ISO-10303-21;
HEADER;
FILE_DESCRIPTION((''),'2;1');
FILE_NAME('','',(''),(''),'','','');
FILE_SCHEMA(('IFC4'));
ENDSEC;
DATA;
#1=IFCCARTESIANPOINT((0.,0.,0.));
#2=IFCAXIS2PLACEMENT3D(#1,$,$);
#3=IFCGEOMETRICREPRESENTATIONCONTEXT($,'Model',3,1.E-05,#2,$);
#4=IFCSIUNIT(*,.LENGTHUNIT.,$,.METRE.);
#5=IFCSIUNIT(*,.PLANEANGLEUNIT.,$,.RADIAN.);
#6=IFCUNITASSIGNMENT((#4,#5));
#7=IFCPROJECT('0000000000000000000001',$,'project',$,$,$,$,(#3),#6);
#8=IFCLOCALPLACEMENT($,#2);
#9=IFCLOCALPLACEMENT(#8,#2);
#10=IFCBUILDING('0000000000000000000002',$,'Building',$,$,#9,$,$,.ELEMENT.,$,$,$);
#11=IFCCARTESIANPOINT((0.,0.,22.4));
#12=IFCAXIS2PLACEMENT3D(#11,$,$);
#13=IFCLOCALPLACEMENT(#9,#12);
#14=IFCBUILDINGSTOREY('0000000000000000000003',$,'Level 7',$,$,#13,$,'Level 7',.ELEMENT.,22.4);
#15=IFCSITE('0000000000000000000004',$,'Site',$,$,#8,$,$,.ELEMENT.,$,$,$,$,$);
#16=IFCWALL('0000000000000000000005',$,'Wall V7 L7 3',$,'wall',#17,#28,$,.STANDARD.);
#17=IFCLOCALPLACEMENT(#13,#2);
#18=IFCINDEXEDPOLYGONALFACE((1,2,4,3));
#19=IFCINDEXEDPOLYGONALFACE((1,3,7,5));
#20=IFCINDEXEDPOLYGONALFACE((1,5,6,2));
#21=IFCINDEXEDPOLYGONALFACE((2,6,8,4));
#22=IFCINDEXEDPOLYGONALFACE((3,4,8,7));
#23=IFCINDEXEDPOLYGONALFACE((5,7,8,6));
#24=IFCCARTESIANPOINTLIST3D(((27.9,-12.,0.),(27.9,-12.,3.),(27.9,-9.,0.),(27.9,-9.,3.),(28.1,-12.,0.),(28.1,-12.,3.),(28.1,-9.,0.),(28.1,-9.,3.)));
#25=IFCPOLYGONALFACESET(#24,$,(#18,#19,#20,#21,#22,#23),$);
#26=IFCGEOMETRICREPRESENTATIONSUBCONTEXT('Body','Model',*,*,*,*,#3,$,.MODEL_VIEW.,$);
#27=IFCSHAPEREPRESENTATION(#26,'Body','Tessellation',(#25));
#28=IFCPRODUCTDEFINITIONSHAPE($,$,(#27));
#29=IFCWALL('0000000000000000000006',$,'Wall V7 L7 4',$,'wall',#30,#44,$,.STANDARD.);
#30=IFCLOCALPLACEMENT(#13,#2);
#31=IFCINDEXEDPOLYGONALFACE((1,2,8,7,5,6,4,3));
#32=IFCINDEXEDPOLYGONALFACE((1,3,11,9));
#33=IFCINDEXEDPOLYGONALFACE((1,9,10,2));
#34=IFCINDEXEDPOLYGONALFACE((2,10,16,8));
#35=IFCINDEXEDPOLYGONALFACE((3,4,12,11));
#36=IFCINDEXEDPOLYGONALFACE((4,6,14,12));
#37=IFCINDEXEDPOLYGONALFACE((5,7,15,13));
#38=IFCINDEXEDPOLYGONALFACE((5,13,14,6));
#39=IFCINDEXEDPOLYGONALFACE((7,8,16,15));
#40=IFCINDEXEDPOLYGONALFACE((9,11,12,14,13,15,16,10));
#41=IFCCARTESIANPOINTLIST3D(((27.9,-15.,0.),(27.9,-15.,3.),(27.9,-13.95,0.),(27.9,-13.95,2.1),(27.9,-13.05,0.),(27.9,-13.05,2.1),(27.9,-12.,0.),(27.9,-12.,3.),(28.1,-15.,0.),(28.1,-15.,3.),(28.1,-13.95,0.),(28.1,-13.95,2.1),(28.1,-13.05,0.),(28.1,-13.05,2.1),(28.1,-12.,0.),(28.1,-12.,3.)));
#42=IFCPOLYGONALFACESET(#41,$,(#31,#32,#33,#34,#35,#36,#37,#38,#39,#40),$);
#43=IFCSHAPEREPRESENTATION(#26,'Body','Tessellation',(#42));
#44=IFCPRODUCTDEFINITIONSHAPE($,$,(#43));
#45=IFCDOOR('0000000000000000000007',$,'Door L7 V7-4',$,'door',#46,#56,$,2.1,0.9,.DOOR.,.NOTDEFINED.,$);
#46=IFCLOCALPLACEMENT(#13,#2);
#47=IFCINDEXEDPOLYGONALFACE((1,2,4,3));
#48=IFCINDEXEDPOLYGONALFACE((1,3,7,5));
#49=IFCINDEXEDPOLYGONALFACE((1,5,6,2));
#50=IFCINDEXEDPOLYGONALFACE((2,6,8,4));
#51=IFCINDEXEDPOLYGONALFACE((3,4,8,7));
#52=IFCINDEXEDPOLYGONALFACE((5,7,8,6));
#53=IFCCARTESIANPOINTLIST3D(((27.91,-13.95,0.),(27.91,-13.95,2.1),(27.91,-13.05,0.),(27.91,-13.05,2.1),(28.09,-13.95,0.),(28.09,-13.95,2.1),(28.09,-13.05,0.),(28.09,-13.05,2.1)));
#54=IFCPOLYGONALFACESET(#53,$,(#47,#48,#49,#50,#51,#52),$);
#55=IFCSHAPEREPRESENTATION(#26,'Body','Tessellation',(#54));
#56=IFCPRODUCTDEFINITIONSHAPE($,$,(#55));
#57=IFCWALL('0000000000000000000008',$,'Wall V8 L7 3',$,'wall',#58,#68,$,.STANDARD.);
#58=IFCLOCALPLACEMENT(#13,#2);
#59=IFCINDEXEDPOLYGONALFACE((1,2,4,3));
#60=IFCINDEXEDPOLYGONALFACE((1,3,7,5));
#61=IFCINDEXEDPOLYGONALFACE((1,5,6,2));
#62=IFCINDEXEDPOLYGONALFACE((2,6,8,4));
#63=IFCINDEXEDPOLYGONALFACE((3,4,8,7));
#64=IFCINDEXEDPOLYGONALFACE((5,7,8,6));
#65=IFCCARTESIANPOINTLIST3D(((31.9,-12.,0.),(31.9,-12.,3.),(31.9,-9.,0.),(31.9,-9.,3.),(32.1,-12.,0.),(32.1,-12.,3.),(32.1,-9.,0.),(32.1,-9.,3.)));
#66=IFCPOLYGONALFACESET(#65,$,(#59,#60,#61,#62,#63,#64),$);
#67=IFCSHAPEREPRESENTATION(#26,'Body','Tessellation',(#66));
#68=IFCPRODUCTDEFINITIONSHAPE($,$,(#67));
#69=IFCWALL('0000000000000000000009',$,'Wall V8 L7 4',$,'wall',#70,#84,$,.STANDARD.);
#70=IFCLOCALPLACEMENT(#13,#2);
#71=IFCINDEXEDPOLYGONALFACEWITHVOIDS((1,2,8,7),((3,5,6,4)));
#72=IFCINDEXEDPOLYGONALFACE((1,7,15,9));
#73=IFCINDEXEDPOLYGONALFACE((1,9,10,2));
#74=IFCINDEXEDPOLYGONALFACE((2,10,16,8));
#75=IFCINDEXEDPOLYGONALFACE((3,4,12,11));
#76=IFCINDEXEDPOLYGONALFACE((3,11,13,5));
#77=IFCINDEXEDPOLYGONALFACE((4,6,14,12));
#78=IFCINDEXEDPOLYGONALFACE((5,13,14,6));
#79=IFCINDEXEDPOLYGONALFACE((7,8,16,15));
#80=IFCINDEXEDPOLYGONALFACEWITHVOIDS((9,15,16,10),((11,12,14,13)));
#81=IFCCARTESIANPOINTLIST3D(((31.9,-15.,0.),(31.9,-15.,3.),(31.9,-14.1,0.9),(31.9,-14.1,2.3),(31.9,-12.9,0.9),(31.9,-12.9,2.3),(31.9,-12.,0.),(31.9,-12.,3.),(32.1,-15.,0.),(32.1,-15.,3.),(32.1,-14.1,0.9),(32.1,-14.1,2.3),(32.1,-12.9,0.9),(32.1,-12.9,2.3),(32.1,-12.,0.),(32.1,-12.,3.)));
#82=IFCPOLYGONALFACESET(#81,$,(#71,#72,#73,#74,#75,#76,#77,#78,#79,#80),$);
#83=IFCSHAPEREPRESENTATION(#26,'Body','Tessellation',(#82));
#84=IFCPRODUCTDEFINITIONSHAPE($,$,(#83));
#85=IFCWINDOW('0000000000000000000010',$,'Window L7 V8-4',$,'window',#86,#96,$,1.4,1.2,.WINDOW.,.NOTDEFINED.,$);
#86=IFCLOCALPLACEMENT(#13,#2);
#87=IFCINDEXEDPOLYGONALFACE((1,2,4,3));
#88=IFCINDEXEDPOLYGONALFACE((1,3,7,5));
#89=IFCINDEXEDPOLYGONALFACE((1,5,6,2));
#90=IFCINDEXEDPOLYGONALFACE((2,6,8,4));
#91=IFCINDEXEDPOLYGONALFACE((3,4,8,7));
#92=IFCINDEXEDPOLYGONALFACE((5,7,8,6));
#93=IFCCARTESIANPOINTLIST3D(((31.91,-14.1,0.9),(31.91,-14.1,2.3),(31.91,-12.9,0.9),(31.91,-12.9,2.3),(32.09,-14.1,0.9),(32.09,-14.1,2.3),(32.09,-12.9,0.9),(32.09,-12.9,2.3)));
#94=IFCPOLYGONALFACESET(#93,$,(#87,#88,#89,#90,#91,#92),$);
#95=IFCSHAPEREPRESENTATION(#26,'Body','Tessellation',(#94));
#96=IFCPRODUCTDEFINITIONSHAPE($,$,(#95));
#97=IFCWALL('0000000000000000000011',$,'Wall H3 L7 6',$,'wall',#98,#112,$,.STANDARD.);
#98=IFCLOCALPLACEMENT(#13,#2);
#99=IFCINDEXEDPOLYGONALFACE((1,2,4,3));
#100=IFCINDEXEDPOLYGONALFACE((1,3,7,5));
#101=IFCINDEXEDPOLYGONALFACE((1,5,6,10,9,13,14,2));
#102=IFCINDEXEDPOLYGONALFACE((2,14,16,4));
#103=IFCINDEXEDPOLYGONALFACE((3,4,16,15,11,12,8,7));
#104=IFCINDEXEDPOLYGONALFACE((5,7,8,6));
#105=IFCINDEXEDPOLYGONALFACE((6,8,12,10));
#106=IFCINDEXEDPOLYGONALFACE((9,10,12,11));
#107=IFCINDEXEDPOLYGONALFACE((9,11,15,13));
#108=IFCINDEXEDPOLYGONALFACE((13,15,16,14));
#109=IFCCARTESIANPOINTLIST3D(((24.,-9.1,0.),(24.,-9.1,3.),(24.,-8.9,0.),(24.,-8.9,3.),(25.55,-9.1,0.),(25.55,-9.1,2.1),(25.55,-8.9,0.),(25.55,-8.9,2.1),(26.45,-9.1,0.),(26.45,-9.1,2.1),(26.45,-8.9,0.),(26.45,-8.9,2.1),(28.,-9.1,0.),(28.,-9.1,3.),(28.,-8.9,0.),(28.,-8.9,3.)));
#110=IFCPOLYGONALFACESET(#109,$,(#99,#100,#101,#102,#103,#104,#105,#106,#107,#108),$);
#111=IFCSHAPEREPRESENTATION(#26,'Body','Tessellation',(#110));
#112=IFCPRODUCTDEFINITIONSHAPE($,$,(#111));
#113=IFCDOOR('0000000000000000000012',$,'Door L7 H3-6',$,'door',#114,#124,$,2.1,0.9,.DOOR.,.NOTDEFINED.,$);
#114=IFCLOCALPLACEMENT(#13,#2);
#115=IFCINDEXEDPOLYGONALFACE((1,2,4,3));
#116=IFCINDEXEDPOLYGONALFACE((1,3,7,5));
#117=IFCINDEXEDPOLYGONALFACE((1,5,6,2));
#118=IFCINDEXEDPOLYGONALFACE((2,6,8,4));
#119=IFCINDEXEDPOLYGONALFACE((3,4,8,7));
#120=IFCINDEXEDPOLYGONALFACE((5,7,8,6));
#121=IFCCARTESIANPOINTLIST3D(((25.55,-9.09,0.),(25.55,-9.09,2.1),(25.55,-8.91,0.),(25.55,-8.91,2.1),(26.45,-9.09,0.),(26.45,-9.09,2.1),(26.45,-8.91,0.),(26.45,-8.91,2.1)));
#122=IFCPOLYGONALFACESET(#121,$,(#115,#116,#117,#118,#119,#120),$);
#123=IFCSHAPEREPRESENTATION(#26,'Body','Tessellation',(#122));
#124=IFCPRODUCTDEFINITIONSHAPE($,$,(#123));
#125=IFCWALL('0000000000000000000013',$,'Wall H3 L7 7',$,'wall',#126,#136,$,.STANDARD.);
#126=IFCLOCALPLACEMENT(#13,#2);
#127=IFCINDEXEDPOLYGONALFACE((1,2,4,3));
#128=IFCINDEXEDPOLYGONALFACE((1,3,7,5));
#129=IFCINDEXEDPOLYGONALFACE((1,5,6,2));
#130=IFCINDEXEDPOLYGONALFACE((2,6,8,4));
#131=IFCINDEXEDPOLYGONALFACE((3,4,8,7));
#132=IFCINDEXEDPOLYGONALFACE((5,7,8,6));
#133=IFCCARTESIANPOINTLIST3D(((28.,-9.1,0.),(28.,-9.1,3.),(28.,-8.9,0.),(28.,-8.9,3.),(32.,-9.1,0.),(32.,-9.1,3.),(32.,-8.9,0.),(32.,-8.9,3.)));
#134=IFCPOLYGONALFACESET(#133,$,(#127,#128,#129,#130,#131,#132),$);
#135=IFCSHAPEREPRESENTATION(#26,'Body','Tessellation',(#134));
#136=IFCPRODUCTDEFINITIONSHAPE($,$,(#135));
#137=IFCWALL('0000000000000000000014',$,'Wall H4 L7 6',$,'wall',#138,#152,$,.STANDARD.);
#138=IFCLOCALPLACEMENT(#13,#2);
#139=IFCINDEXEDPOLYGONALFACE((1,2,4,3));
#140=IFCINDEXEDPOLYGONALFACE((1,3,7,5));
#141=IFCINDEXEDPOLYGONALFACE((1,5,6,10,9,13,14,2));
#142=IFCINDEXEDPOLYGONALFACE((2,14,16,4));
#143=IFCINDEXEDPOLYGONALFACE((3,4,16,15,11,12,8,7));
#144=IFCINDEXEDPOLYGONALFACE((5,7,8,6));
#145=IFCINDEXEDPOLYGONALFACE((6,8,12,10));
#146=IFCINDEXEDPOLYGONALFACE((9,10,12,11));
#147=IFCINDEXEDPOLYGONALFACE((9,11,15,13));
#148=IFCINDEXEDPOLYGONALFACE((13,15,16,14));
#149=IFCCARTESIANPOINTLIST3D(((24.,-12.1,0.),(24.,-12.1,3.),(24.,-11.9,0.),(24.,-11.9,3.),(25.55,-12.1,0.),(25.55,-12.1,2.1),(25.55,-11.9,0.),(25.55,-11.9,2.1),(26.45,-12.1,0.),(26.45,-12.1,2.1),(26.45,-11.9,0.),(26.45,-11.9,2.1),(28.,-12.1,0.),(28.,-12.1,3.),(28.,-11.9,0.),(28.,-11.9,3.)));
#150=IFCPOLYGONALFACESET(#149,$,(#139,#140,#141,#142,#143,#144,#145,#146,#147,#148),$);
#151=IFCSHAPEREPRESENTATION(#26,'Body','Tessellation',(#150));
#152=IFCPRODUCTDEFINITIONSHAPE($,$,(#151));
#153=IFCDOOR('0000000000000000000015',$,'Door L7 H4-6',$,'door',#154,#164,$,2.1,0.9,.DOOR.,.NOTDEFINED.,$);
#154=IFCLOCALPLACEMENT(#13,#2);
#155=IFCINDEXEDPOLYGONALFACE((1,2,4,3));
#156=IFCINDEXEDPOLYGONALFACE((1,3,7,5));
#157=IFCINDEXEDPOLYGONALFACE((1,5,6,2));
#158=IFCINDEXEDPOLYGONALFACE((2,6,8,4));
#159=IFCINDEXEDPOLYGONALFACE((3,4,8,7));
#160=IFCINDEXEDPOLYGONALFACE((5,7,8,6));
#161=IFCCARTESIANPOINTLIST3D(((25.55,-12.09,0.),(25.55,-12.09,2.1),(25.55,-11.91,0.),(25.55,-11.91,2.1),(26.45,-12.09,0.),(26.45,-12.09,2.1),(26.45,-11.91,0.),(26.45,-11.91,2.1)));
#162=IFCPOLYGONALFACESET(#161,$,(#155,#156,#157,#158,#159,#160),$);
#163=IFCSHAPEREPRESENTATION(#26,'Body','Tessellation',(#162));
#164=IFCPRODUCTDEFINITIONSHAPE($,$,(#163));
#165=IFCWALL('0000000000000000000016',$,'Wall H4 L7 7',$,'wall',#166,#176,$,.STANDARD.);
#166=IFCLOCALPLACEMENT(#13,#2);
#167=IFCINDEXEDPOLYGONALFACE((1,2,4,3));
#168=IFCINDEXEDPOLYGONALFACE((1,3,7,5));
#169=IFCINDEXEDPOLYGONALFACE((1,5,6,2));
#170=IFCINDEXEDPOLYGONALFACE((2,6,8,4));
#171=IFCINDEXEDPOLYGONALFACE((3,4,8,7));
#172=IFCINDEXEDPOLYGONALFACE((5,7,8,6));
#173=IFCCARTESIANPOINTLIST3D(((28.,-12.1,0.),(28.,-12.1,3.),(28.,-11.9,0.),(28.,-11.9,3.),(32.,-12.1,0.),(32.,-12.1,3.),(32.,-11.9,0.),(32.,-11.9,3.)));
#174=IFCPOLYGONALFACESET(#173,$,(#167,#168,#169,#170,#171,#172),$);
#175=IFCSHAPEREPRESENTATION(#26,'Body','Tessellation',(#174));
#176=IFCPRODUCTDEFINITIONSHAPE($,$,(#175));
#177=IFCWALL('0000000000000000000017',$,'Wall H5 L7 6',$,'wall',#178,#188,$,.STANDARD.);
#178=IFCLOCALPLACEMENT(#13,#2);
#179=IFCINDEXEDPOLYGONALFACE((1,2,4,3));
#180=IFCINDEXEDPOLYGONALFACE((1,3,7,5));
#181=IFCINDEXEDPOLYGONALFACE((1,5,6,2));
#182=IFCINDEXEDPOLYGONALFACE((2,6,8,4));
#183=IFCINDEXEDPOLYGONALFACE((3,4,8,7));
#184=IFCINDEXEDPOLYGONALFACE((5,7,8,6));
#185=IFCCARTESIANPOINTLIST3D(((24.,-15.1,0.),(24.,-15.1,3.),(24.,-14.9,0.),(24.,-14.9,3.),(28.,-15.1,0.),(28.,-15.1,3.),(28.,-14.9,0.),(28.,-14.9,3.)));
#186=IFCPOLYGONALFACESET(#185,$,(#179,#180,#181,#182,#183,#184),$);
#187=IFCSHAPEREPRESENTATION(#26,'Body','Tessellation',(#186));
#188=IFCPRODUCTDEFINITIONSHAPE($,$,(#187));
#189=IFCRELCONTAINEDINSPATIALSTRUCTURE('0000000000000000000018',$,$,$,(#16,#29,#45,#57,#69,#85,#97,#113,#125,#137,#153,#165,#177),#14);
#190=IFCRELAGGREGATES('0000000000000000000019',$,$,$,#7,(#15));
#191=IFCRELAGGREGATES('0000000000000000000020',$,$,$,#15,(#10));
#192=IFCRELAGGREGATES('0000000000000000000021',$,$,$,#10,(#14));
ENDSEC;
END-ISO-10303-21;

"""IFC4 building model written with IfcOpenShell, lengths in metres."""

from ifc_helpers import new_model, si_unit, frame, frame_2d, origin, origin_2d, place, context, subcontext, project, spatial, rectangle, extrude, element, fill, save


model = new_model("IFC4")

# Units and contexts
model_context = context("Model", 3, precision=1e-05, world=origin())
body_context = subcontext(model_context, "Body", "Model", "MODEL_VIEW")
ifc_project = project(units=[si_unit("LENGTHUNIT", "METRE"), si_unit("PLANEANGLEUNIT", "RADIAN")], contexts=[model_context])

# Site, building, storey
site_placement = place(None, origin())
site = spatial("IfcSite", under=ifc_project, at=site_placement, Name="Site", CompositionType="ELEMENT")
building_placement = place(site_placement, origin())
building = spatial("IfcBuilding", under=site, at=building_placement, Name="Building", CompositionType="ELEMENT")
storey_placement = place(building_placement, frame((0.0, 0.0, 22.4)))
storey = spatial("IfcBuildingStorey", under=building, at=storey_placement, Name="Level 7", LongName="Level 7", CompositionType="ELEMENT", Elevation=22.4)

# Wall
wall_1_placement = place(storey_placement, frame((28.0, -9.0, 0.0), z_axis=(0.0, 0.0, 1.0), x_axis=(0.0, -1.0, 0.0)))
element("IfcWall", 1, at=wall_1_placement, inside=storey, Name="Wall V7 L7 3", ObjectType="wall", PredefinedType="STANDARD", context=body_context, shape_type="SweptSolid", body=[
    extrude(rectangle(XDim=3.0, YDim=0.2, at=frame_2d((1.5, 0.0))), origin(), (0.0, 0.0, 1.0), 3.0),
])

# Wall, opening, door
wall_2_placement = place(storey_placement, frame((28.0, -12.0, 0.0), z_axis=(0.0, 0.0, 1.0), x_axis=(0.0, -1.0, 0.0)))
wall_2 = element("IfcWall", 2, at=wall_2_placement, inside=storey, Name="Wall V7 L7 4", ObjectType="wall", PredefinedType="STANDARD", context=body_context, shape_type="SweptSolid", body=[
    extrude(rectangle(XDim=3.0, YDim=0.2, at=frame_2d((1.5, 0.0))), origin(), (0.0, 0.0, 1.0), 3.0),
])
opening_1_placement = place(storey_placement, frame((28.0, -13.5, 0.0), z_axis=(0.0, 0.0, 1.0), x_axis=(0.0, -1.0, 0.0)))
opening_1 = element("IfcOpeningElement", 3, at=opening_1_placement, cuts=wall_2, ObjectType="Opening", PredefinedType="OPENING", context=body_context, shape_type="SweptSolid", body=[
    extrude(rectangle(XDim=0.9, YDim=0.22, at=origin_2d()), origin(), (0.0, 0.0, 1.0), 2.1),
])
door_1_placement = place(storey_placement, frame((28.0, -13.5, 0.0), z_axis=(0.0, 0.0, 1.0), x_axis=(0.0, -1.0, 0.0)))
door_1 = element("IfcDoor", 4, at=door_1_placement, inside=storey, Name="Door L7 V7-4", ObjectType="door", OperationType="NOTDEFINED", OverallHeight=2.1, OverallWidth=0.9, PredefinedType="DOOR", context=body_context, shape_type="SweptSolid", body=[
    extrude(rectangle(XDim=0.9, YDim=0.18, at=origin_2d()), origin(), (0.0, 0.0, 1.0), 2.1),
])
fill(opening_1, door_1)

# Wall
wall_3_placement = place(storey_placement, frame((32.0, -9.0, 0.0), z_axis=(0.0, 0.0, 1.0), x_axis=(0.0, -1.0, 0.0)))
element("IfcWall", 5, at=wall_3_placement, inside=storey, Name="Wall V8 L7 3", ObjectType="wall", PredefinedType="STANDARD", context=body_context, shape_type="SweptSolid", body=[
    extrude(rectangle(XDim=3.0, YDim=0.2, at=frame_2d((1.5, 0.0))), origin(), (0.0, 0.0, 1.0), 3.0),
])

# Wall, opening, window
wall_4_placement = place(storey_placement, frame((32.0, -12.0, 0.0), z_axis=(0.0, 0.0, 1.0), x_axis=(0.0, -1.0, 0.0)))
wall_4 = element("IfcWall", 6, at=wall_4_placement, inside=storey, Name="Wall V8 L7 4", ObjectType="wall", PredefinedType="STANDARD", context=body_context, shape_type="SweptSolid", body=[
    extrude(rectangle(XDim=3.0, YDim=0.2, at=frame_2d((1.5, 0.0))), origin(), (0.0, 0.0, 1.0), 3.0),
])
opening_2_placement = place(storey_placement, frame((32.0, -13.5, 0.9), z_axis=(0.0, 0.0, 1.0), x_axis=(0.0, -1.0, 0.0)))
opening_2 = element("IfcOpeningElement", 7, at=opening_2_placement, cuts=wall_4, ObjectType="Opening", PredefinedType="OPENING", context=body_context, shape_type="SweptSolid", body=[
    extrude(rectangle(XDim=1.2, YDim=0.22, at=origin_2d()), origin(), (0.0, 0.0, 1.0), 1.4),
])
window_1_placement = place(storey_placement, frame((32.0, -13.5, 0.9), z_axis=(0.0, 0.0, 1.0), x_axis=(0.0, -1.0, 0.0)))
window_1 = element("IfcWindow", 8, at=window_1_placement, inside=storey, Name="Window L7 V8-4", ObjectType="window", OverallHeight=1.4, OverallWidth=1.2, PartitioningType="NOTDEFINED", PredefinedType="WINDOW", context=body_context, shape_type="SweptSolid", body=[
    extrude(rectangle(XDim=1.2, YDim=0.18, at=origin_2d()), origin(), (0.0, 0.0, 1.0), 1.4),
])
fill(opening_2, window_1)

# Wall, opening, door
wall_5_placement = place(storey_placement, frame((24.0, -9.0, 0.0), z_axis=(0.0, 0.0, 1.0), x_axis=(1.0, 0.0, 0.0)))
wall_5 = element("IfcWall", 9, at=wall_5_placement, inside=storey, Name="Wall H3 L7 6", ObjectType="wall", PredefinedType="STANDARD", context=body_context, shape_type="SweptSolid", body=[
    extrude(rectangle(XDim=4.0, YDim=0.2, at=frame_2d((2.0, 0.0))), origin(), (0.0, 0.0, 1.0), 3.0),
])
opening_3_placement = place(storey_placement, frame((26.0, -9.0, 0.0), z_axis=(0.0, 0.0, 1.0), x_axis=(1.0, 0.0, 0.0)))
opening_3 = element("IfcOpeningElement", 10, at=opening_3_placement, cuts=wall_5, ObjectType="Opening", PredefinedType="OPENING", context=body_context, shape_type="SweptSolid", body=[
    extrude(rectangle(XDim=0.9, YDim=0.22, at=origin_2d()), origin(), (0.0, 0.0, 1.0), 2.1),
])
door_2_placement = place(storey_placement, frame((26.0, -9.0, 0.0), z_axis=(0.0, 0.0, 1.0), x_axis=(1.0, 0.0, 0.0)))
door_2 = element("IfcDoor", 11, at=door_2_placement, inside=storey, Name="Door L7 H3-6", ObjectType="door", OperationType="NOTDEFINED", OverallHeight=2.1, OverallWidth=0.9, PredefinedType="DOOR", context=body_context, shape_type="SweptSolid", body=[
    extrude(rectangle(XDim=0.9, YDim=0.18, at=origin_2d()), origin(), (0.0, 0.0, 1.0), 2.1),
])
fill(opening_3, door_2)

# Wall
wall_6_placement = place(storey_placement, frame((28.0, -9.0, 0.0), z_axis=(0.0, 0.0, 1.0), x_axis=(1.0, 0.0, 0.0)))
element("IfcWall", 12, at=wall_6_placement, inside=storey, Name="Wall H3 L7 7", ObjectType="wall", PredefinedType="STANDARD", context=body_context, shape_type="SweptSolid", body=[
    extrude(rectangle(XDim=4.0, YDim=0.2, at=frame_2d((2.0, 0.0))), origin(), (0.0, 0.0, 1.0), 3.0),
])

# Wall, opening, door
wall_7_placement = place(storey_placement, frame((24.0, -12.0, 0.0), z_axis=(0.0, 0.0, 1.0), x_axis=(1.0, 0.0, 0.0)))
wall_7 = element("IfcWall", 13, at=wall_7_placement, inside=storey, Name="Wall H4 L7 6", ObjectType="wall", PredefinedType="STANDARD", context=body_context, shape_type="SweptSolid", body=[
    extrude(rectangle(XDim=4.0, YDim=0.2, at=frame_2d((2.0, 0.0))), origin(), (0.0, 0.0, 1.0), 3.0),
])
opening_4_placement = place(storey_placement, frame((26.0, -12.0, 0.0), z_axis=(0.0, 0.0, 1.0), x_axis=(1.0, 0.0, 0.0)))
opening_4 = element("IfcOpeningElement", 14, at=opening_4_placement, cuts=wall_7, ObjectType="Opening", PredefinedType="OPENING", context=body_context, shape_type="SweptSolid", body=[
    extrude(rectangle(XDim=0.9, YDim=0.22, at=origin_2d()), origin(), (0.0, 0.0, 1.0), 2.1),
])
door_3_placement = place(storey_placement, frame((26.0, -12.0, 0.0), z_axis=(0.0, 0.0, 1.0), x_axis=(1.0, 0.0, 0.0)))
door_3 = element("IfcDoor", 15, at=door_3_placement, inside=storey, Name="Door L7 H4-6", ObjectType="door", OperationType="NOTDEFINED", OverallHeight=2.1, OverallWidth=0.9, PredefinedType="DOOR", context=body_context, shape_type="SweptSolid", body=[
    extrude(rectangle(XDim=0.9, YDim=0.18, at=origin_2d()), origin(), (0.0, 0.0, 1.0), 2.1),
])
fill(opening_4, door_3)

# Walls
for number, where, z_axis, x_axis, name in (
    (16, (28.0, -12.0, 0.0), (0.0, 0.0, 1.0), (1.0, 0.0, 0.0), "Wall H4 L7 7"),
    (17, (24.0, -15.0, 0.0), (0.0, 0.0, 1.0), (1.0, 0.0, 0.0), "Wall H5 L7 6"),
):
    element("IfcWall", number, at=place(storey_placement, frame(where, z_axis=z_axis, x_axis=x_axis)), inside=storey, Name=name, ObjectType="wall", PredefinedType="STANDARD", context=body_context, shape_type="SweptSolid", body=[
        extrude(rectangle(XDim=4.0, YDim=0.2, at=frame_2d((2.0, 0.0))), origin(), (0.0, 0.0, 1.0), 3.0),
    ])

save(model, "model.ifc")
